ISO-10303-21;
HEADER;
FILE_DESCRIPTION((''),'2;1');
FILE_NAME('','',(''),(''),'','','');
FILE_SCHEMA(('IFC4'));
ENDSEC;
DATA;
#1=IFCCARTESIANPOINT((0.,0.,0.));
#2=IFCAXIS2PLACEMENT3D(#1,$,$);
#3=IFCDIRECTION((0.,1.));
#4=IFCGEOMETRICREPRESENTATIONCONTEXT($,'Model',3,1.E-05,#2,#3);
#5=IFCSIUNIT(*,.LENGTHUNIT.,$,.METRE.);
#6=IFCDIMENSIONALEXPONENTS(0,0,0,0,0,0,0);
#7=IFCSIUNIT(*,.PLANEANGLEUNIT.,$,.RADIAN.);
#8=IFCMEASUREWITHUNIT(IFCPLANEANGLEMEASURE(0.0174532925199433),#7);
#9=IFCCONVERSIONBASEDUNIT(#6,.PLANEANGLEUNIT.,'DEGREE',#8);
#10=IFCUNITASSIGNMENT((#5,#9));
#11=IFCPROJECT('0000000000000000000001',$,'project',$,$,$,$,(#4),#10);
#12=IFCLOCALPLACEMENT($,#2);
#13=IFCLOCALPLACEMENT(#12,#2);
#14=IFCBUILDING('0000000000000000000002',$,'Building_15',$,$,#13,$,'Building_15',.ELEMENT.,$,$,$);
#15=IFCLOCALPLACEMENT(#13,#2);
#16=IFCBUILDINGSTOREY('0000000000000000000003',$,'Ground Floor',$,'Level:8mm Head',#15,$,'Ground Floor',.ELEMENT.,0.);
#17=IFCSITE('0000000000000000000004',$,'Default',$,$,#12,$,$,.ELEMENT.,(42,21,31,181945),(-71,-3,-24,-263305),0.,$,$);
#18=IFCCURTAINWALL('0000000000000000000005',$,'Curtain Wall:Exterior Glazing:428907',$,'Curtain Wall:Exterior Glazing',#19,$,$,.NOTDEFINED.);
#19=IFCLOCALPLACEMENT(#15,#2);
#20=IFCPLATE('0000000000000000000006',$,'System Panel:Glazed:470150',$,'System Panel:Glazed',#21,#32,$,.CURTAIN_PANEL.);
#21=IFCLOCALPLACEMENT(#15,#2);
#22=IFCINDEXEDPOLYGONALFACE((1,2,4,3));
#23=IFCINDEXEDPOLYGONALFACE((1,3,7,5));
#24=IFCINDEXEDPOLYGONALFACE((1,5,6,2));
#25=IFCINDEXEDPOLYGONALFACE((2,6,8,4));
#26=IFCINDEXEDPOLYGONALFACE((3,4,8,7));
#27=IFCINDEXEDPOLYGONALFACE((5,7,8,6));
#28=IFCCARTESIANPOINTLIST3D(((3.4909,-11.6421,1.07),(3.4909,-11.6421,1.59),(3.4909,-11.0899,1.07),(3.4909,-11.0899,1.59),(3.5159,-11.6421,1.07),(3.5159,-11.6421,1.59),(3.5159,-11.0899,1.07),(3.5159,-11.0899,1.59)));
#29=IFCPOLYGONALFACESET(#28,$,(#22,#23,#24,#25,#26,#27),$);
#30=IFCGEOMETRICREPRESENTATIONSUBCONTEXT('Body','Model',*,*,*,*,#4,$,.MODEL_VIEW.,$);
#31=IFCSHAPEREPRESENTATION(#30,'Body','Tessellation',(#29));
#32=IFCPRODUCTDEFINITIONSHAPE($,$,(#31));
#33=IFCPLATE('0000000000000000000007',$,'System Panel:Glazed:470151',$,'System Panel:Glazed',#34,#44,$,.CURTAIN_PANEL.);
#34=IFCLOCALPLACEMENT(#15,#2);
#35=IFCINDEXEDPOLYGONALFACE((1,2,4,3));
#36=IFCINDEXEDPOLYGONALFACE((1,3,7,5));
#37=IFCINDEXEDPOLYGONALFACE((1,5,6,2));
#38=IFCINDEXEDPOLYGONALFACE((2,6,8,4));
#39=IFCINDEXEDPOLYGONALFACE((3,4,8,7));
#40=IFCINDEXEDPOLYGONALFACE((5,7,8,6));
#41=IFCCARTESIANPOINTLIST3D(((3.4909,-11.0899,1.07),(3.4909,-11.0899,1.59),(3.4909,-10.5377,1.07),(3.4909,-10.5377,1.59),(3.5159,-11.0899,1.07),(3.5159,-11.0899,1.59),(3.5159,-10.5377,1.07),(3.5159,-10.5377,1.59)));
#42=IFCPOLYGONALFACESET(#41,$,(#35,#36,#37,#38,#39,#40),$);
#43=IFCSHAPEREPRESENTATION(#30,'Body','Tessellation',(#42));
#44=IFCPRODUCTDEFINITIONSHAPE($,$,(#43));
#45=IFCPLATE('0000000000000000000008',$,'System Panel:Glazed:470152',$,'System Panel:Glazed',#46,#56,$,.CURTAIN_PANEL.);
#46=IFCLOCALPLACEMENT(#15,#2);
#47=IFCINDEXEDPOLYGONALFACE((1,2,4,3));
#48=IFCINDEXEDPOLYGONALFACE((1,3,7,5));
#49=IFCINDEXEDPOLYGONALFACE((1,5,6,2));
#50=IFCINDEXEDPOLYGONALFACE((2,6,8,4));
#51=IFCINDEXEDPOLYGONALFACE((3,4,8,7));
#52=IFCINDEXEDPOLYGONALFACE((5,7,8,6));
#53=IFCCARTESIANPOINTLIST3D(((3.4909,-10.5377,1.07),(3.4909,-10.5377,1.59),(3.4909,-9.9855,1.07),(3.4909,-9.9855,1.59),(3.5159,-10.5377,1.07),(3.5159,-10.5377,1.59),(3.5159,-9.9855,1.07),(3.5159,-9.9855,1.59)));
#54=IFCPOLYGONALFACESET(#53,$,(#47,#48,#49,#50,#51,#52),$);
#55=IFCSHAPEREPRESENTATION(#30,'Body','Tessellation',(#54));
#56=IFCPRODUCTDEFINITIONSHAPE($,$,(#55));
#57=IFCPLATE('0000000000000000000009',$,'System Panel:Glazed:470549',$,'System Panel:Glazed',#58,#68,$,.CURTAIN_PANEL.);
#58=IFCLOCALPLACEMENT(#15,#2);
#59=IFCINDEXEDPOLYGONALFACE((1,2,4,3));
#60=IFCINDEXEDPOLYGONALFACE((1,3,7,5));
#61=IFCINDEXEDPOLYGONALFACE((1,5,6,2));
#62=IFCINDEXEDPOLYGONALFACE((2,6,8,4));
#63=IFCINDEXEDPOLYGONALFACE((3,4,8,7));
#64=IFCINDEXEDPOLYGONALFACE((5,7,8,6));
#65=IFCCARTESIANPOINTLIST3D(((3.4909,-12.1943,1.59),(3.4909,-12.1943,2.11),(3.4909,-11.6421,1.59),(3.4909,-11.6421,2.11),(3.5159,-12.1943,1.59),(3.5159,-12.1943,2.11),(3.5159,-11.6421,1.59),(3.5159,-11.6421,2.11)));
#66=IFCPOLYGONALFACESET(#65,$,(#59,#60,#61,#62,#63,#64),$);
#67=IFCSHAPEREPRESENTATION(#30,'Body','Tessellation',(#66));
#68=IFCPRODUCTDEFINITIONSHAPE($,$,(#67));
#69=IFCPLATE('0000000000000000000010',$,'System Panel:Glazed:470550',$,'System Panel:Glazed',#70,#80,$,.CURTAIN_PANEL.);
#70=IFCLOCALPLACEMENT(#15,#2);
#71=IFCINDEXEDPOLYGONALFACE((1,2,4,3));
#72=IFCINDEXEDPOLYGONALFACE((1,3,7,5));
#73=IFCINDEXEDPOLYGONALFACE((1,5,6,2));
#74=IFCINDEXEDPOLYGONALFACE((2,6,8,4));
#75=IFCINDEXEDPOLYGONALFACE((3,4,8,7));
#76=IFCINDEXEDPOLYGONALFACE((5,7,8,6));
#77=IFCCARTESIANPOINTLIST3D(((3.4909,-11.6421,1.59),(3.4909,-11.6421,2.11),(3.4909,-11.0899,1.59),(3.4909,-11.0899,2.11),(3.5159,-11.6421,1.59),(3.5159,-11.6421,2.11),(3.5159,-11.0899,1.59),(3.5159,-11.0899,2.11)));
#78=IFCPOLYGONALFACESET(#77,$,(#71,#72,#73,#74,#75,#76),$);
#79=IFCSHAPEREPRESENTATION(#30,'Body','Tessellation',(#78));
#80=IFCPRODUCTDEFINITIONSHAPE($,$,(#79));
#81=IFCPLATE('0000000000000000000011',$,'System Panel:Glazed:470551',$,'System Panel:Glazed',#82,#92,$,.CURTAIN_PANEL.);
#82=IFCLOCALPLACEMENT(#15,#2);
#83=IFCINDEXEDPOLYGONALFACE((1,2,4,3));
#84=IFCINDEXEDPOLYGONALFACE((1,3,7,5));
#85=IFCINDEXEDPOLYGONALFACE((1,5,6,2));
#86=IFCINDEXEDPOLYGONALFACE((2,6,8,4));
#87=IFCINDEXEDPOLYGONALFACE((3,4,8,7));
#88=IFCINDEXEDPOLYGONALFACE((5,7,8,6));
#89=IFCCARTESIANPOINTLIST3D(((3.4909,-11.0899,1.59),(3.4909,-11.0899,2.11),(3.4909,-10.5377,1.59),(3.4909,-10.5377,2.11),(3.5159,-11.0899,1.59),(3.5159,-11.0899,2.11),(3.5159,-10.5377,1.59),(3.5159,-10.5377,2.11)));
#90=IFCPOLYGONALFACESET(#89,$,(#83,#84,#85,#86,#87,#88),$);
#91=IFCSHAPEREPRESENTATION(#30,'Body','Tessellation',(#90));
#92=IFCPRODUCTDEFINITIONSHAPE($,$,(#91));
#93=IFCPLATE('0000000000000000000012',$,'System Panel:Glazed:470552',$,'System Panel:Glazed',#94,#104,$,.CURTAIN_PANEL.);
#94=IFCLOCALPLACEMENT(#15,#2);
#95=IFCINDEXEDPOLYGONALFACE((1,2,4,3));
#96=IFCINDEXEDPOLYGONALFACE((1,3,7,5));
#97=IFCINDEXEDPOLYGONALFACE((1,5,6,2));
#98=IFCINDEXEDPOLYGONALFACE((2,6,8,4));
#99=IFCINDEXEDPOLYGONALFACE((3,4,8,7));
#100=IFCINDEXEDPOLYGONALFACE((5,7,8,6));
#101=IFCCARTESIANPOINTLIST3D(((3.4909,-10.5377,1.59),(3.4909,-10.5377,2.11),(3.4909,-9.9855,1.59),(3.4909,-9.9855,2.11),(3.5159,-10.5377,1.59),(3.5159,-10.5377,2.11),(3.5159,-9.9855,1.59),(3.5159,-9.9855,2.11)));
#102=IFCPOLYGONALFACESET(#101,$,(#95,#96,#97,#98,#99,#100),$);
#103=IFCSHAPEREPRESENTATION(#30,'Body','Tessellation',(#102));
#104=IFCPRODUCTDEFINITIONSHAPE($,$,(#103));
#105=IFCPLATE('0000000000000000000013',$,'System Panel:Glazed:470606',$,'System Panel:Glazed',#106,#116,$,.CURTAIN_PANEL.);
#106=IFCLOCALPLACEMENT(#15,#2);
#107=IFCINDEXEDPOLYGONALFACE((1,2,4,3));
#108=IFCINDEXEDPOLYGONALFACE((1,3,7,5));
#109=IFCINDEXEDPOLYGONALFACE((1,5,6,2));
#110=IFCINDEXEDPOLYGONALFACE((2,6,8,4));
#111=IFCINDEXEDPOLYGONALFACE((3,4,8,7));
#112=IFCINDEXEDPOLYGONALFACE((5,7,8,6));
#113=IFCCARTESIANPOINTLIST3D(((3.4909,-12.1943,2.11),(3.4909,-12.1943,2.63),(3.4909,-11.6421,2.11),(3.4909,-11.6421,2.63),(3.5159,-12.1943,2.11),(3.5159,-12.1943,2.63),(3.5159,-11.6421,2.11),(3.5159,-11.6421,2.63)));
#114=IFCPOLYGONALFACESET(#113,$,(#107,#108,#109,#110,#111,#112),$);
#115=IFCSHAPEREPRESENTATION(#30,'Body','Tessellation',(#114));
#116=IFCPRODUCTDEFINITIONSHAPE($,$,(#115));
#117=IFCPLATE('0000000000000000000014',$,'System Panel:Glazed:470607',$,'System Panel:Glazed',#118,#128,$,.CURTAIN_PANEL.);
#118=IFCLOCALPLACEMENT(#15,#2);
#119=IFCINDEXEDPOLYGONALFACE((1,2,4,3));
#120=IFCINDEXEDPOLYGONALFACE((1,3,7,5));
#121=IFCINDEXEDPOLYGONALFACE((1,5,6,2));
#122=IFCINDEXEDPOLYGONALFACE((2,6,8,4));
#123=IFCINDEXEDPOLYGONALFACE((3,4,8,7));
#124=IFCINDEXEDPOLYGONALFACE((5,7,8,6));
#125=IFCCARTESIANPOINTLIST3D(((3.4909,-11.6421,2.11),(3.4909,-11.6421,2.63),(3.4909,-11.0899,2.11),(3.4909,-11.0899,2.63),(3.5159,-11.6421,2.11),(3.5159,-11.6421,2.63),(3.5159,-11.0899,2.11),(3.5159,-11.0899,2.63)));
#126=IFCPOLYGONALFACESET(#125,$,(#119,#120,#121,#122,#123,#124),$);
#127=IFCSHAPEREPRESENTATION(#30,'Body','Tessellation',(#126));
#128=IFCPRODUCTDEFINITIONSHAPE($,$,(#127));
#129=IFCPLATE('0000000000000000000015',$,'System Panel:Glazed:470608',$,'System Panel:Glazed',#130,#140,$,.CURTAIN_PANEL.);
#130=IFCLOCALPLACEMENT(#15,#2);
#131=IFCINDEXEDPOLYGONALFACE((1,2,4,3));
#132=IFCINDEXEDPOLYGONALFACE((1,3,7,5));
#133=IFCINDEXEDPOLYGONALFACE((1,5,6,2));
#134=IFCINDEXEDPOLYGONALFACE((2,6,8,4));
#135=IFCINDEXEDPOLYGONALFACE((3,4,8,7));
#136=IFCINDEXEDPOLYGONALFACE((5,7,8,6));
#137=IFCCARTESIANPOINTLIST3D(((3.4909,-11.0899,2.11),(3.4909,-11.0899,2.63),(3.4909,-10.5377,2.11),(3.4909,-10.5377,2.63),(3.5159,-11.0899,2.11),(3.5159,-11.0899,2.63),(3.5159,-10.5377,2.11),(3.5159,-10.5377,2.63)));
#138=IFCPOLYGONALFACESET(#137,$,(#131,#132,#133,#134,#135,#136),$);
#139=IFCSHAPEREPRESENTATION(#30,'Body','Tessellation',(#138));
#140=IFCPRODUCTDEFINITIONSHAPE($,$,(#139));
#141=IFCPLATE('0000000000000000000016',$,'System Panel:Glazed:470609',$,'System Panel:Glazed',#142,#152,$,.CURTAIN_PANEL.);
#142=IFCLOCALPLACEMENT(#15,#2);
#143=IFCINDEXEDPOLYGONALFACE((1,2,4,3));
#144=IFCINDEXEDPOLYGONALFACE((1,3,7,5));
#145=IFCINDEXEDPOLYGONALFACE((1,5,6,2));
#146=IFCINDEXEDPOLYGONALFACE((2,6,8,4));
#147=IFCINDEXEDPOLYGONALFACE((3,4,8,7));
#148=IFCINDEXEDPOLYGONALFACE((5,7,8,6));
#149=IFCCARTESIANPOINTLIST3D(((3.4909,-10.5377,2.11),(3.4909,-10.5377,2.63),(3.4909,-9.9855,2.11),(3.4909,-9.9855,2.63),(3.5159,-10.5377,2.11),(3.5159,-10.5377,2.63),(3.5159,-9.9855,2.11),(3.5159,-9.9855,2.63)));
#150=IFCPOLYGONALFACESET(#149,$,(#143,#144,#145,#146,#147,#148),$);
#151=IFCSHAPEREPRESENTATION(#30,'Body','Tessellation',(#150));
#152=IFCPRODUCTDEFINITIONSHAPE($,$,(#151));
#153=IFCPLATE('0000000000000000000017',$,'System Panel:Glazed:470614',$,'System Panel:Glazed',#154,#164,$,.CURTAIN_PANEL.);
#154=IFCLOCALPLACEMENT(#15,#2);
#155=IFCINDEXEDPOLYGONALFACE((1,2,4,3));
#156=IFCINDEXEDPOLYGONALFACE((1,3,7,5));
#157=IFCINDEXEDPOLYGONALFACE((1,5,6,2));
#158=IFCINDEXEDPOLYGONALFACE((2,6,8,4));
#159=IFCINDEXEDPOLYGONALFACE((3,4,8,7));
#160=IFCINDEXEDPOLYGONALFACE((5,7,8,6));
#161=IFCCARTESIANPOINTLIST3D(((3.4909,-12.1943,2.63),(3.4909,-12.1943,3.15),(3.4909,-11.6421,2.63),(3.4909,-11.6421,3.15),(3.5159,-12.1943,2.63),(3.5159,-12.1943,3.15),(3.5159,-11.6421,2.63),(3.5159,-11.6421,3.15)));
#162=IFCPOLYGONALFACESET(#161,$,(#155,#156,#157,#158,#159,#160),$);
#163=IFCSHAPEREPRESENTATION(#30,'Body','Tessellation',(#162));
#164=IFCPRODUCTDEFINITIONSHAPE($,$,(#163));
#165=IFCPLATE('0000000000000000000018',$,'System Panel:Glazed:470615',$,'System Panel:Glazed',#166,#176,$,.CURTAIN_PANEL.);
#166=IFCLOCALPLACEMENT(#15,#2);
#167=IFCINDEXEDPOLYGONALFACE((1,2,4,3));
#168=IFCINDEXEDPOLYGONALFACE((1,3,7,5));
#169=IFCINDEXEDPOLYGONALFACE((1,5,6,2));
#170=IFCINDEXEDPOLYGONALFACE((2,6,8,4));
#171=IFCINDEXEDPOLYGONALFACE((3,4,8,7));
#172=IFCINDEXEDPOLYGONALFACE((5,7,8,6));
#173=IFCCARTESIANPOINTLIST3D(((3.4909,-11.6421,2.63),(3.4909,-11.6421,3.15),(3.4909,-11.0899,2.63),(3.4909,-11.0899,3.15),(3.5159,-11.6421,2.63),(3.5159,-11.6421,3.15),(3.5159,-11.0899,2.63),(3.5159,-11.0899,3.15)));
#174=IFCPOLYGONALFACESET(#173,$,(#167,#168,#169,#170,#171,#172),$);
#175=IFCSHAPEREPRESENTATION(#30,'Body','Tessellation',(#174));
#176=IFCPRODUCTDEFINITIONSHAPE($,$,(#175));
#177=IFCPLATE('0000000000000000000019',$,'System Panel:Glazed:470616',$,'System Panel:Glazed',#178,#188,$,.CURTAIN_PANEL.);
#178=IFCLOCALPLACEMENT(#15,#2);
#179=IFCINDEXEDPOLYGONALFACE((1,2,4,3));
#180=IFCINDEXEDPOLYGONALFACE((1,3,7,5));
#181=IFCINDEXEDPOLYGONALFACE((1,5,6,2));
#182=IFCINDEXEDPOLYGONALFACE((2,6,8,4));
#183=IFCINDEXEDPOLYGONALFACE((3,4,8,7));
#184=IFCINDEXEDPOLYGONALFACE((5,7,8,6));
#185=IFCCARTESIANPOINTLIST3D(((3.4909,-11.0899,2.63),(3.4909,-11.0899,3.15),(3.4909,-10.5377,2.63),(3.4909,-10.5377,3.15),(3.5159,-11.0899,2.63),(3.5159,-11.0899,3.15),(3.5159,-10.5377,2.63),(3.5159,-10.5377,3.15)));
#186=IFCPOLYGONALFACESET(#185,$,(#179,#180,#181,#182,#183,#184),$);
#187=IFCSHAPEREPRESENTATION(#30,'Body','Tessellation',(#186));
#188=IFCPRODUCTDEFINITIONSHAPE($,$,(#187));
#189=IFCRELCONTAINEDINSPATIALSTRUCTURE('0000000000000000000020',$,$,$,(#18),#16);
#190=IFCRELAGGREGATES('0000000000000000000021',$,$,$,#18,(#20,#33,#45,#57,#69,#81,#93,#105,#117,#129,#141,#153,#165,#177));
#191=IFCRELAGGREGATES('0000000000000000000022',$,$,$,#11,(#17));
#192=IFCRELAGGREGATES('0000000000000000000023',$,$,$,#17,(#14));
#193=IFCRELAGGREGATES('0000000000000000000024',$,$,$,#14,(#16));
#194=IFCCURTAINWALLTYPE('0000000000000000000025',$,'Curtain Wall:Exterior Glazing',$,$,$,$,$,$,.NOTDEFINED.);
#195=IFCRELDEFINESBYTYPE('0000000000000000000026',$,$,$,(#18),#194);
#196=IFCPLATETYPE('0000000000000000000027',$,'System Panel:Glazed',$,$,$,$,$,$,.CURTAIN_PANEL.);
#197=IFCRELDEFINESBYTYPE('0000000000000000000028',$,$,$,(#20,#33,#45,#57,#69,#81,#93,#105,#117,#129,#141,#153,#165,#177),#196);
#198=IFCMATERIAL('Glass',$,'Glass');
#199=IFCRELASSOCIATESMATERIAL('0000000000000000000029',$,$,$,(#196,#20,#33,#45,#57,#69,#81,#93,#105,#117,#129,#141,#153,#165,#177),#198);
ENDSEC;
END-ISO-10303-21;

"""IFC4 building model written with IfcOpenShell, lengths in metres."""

from ifc_helpers import new_model, entity, si_unit, converted_unit, direction, frame, origin, place, context, subcontext, project, spatial, indexed_curve, outline, extrude, source, transform, mapped, material, type_object, type_shapes, element, aggregate, save


model = new_model("IFC4")

# Units and contexts
model_context = context("Model", 3, precision=1e-05, world=origin(), true_north=direction((0.0, 1.0)))
body_context = subcontext(model_context, "Body", "Model", "MODEL_VIEW")
ifc_project = project(units=[si_unit("LENGTHUNIT", "METRE"), converted_unit("PLANEANGLEUNIT", "DEGREE", entity("IfcPlaneAngleMeasure", 0.0174532925199433), si_unit("PLANEANGLEUNIT", "RADIAN"), dimensions=[0, 0, 0, 0, 0, 0, 0])], contexts=[model_context])

# Site, building, storey
site_placement = place(None, origin())
site = spatial("IfcSite", under=ifc_project, at=site_placement, Name="Default", CompositionType="ELEMENT", RefLatitude=(42, 21, 31, 181945), RefLongitude=(-71, -3, -24, -263305), RefElevation=0.0)
building_placement = place(site_placement, origin())
building = spatial("IfcBuilding", under=site, at=building_placement, Name="Building_15", LongName="Building_15", CompositionType="ELEMENT")
storey_placement = place(building_placement, origin())
storey = spatial("IfcBuildingStorey", under=building, at=storey_placement, Name="Ground Floor", ObjectType="Level:8mm Head", LongName="Ground Floor", CompositionType="ELEMENT", Elevation=0.0)

# Curtain wall, plates
curtain_wall_type = type_object("IfcCurtainWallType", Name="Curtain Wall:Exterior Glazing", PredefinedType="NOTDEFINED")
curtain_wall_placement = place(storey_placement, origin())
curtain_wall = element("IfcCurtainWall", 1, at=curtain_wall_placement, inside=storey, type_object=curtain_wall_type, Name="Curtain Wall:Exterior Glazing:428907", ObjectType="Curtain Wall:Exterior Glazing", PredefinedType="NOTDEFINED")
ifc_material_1 = material(Name="Glass", Category="Glass")
plate_type_1 = type_object("IfcPlateType", Name="System Panel:Glazed", PredefinedType="CURTAIN_PANEL", material=ifc_material_1)
shared_shape_1 = source(origin(), body_context, "Body", "SweptSolid", [
    extrude(outline(indexed_curve([(-0.0125, -0.2761), (0.0125, -0.2761), (0.0125, 0.2761), (-0.0125, 0.2761), (-0.0125, -0.2761)], self_intersect=False)), frame((0.0, 0.037, 0.0), z_axis=(0.0, 0.0, 1.0), x_axis=(0.0, 1.0, 0.0)), (0.0, 0.0, 1.0), 0.52),
])
type_shapes(plate_type_1, [shared_shape_1])
plate_1_placement = place(curtain_wall_placement, frame((3.5404, -11.366, 1.07), z_axis=(0.0, 0.0, 1.0), x_axis=(0.0, 1.0, 0.0)))
plate_1 = element("IfcPlate", 2, at=plate_1_placement, type_object=plate_type_1, material=ifc_material_1, Name="System Panel:Glazed:470150", ObjectType="System Panel:Glazed", PredefinedType="CURTAIN_PANEL", context=body_context, shape_type="MappedRepresentation", body=[
    mapped(shared_shape_1, transform((0.0, 0.0, 0.0), scale=1.0)),
])
plate_2_placement = place(curtain_wall_placement, frame((3.5404, -10.8138, 1.07), z_axis=(0.0, 0.0, 1.0), x_axis=(0.0, 1.0, 0.0)))
plate_2 = element("IfcPlate", 3, at=plate_2_placement, type_object=plate_type_1, material=ifc_material_1, Name="System Panel:Glazed:470151", ObjectType="System Panel:Glazed", PredefinedType="CURTAIN_PANEL", context=body_context, shape_type="MappedRepresentation", body=[
    mapped(shared_shape_1, transform((0.0, 0.0, 0.0), scale=1.0)),
])
plate_3_placement = place(curtain_wall_placement, frame((3.5404, -10.2616, 1.07), z_axis=(0.0, 0.0, 1.0), x_axis=(0.0, 1.0, 0.0)))
plate_3 = element("IfcPlate", 4, at=plate_3_placement, type_object=plate_type_1, material=ifc_material_1, Name="System Panel:Glazed:470152", ObjectType="System Panel:Glazed", PredefinedType="CURTAIN_PANEL", context=body_context, shape_type="MappedRepresentation", body=[
    mapped(shared_shape_1, transform((0.0, 0.0, 0.0), scale=1.0)),
])
plate_4_placement = place(curtain_wall_placement, frame((3.5404, -11.9182, 1.59), z_axis=(0.0, 0.0, 1.0), x_axis=(0.0, 1.0, 0.0)))
plate_4 = element("IfcPlate", 5, at=plate_4_placement, type_object=plate_type_1, material=ifc_material_1, Name="System Panel:Glazed:470549", ObjectType="System Panel:Glazed", PredefinedType="CURTAIN_PANEL", context=body_context, shape_type="MappedRepresentation", body=[
    mapped(shared_shape_1, transform((0.0, 0.0, 0.0), scale=1.0)),
])
plate_5_placement = place(curtain_wall_placement, frame((3.5404, -11.366, 1.59), z_axis=(0.0, 0.0, 1.0), x_axis=(0.0, 1.0, 0.0)))
plate_5 = element("IfcPlate", 6, at=plate_5_placement, type_object=plate_type_1, material=ifc_material_1, Name="System Panel:Glazed:470550", ObjectType="System Panel:Glazed", PredefinedType="CURTAIN_PANEL", context=body_context, shape_type="MappedRepresentation", body=[
    mapped(shared_shape_1, transform((0.0, 0.0, 0.0), scale=1.0)),
])
plate_6_placement = place(curtain_wall_placement, frame((3.5404, -10.8138, 1.59), z_axis=(0.0, 0.0, 1.0), x_axis=(0.0, 1.0, 0.0)))
plate_6 = element("IfcPlate", 7, at=plate_6_placement, type_object=plate_type_1, material=ifc_material_1, Name="System Panel:Glazed:470551", ObjectType="System Panel:Glazed", PredefinedType="CURTAIN_PANEL", context=body_context, shape_type="MappedRepresentation", body=[
    mapped(shared_shape_1, transform((0.0, 0.0, 0.0), scale=1.0)),
])
plate_7_placement = place(curtain_wall_placement, frame((3.5404, -10.2616, 1.59), z_axis=(0.0, 0.0, 1.0), x_axis=(0.0, 1.0, 0.0)))
plate_7 = element("IfcPlate", 8, at=plate_7_placement, type_object=plate_type_1, material=ifc_material_1, Name="System Panel:Glazed:470552", ObjectType="System Panel:Glazed", PredefinedType="CURTAIN_PANEL", context=body_context, shape_type="MappedRepresentation", body=[
    mapped(shared_shape_1, transform((0.0, 0.0, 0.0), scale=1.0)),
])
plate_8_placement = place(curtain_wall_placement, frame((3.5404, -11.9182, 2.11), z_axis=(0.0, 0.0, 1.0), x_axis=(0.0, 1.0, 0.0)))
plate_8 = element("IfcPlate", 9, at=plate_8_placement, type_object=plate_type_1, material=ifc_material_1, Name="System Panel:Glazed:470606", ObjectType="System Panel:Glazed", PredefinedType="CURTAIN_PANEL", context=body_context, shape_type="MappedRepresentation", body=[
    mapped(shared_shape_1, transform((0.0, 0.0, 0.0), scale=1.0)),
])
plate_9_placement = place(curtain_wall_placement, frame((3.5404, -11.366, 2.11), z_axis=(0.0, 0.0, 1.0), x_axis=(0.0, 1.0, 0.0)))
plate_9 = element("IfcPlate", 10, at=plate_9_placement, type_object=plate_type_1, material=ifc_material_1, Name="System Panel:Glazed:470607", ObjectType="System Panel:Glazed", PredefinedType="CURTAIN_PANEL", context=body_context, shape_type="MappedRepresentation", body=[
    mapped(shared_shape_1, transform((0.0, 0.0, 0.0), scale=1.0)),
])
plate_10_placement = place(curtain_wall_placement, frame((3.5404, -10.8138, 2.11), z_axis=(0.0, 0.0, 1.0), x_axis=(0.0, 1.0, 0.0)))
plate_10 = element("IfcPlate", 11, at=plate_10_placement, type_object=plate_type_1, material=ifc_material_1, Name="System Panel:Glazed:470608", ObjectType="System Panel:Glazed", PredefinedType="CURTAIN_PANEL", context=body_context, shape_type="MappedRepresentation", body=[
    mapped(shared_shape_1, transform((0.0, 0.0, 0.0), scale=1.0)),
])
plate_11_placement = place(curtain_wall_placement, frame((3.5404, -10.2616, 2.11), z_axis=(0.0, 0.0, 1.0), x_axis=(0.0, 1.0, 0.0)))
plate_11 = element("IfcPlate", 12, at=plate_11_placement, type_object=plate_type_1, material=ifc_material_1, Name="System Panel:Glazed:470609", ObjectType="System Panel:Glazed", PredefinedType="CURTAIN_PANEL", context=body_context, shape_type="MappedRepresentation", body=[
    mapped(shared_shape_1, transform((0.0, 0.0, 0.0), scale=1.0)),
])
plate_12_placement = place(curtain_wall_placement, frame((3.5404, -11.9182, 2.63), z_axis=(0.0, 0.0, 1.0), x_axis=(0.0, 1.0, 0.0)))
plate_12 = element("IfcPlate", 13, at=plate_12_placement, type_object=plate_type_1, material=ifc_material_1, Name="System Panel:Glazed:470614", ObjectType="System Panel:Glazed", PredefinedType="CURTAIN_PANEL", context=body_context, shape_type="MappedRepresentation", body=[
    mapped(shared_shape_1, transform((0.0, 0.0, 0.0), scale=1.0)),
])
plate_13_placement = place(curtain_wall_placement, frame((3.5404, -11.366, 2.63), z_axis=(0.0, 0.0, 1.0), x_axis=(0.0, 1.0, 0.0)))
plate_13 = element("IfcPlate", 14, at=plate_13_placement, type_object=plate_type_1, material=ifc_material_1, Name="System Panel:Glazed:470615", ObjectType="System Panel:Glazed", PredefinedType="CURTAIN_PANEL", context=body_context, shape_type="MappedRepresentation", body=[
    mapped(shared_shape_1, transform((0.0, 0.0, 0.0), scale=1.0)),
])
plate_14_placement = place(curtain_wall_placement, frame((3.5404, -10.8138, 2.63), z_axis=(0.0, 0.0, 1.0), x_axis=(0.0, 1.0, 0.0)))
plate_14 = element("IfcPlate", 15, at=plate_14_placement, type_object=plate_type_1, material=ifc_material_1, Name="System Panel:Glazed:470616", ObjectType="System Panel:Glazed", PredefinedType="CURTAIN_PANEL", context=body_context, shape_type="MappedRepresentation", body=[
    mapped(shared_shape_1, transform((0.0, 0.0, 0.0), scale=1.0)),
])
aggregate(curtain_wall, [plate_1, plate_2, plate_3, plate_4, plate_5, plate_6, plate_7, plate_8, plate_9, plate_10, plate_11, plate_12, plate_13, plate_14])

save(model, "model.ifc")
